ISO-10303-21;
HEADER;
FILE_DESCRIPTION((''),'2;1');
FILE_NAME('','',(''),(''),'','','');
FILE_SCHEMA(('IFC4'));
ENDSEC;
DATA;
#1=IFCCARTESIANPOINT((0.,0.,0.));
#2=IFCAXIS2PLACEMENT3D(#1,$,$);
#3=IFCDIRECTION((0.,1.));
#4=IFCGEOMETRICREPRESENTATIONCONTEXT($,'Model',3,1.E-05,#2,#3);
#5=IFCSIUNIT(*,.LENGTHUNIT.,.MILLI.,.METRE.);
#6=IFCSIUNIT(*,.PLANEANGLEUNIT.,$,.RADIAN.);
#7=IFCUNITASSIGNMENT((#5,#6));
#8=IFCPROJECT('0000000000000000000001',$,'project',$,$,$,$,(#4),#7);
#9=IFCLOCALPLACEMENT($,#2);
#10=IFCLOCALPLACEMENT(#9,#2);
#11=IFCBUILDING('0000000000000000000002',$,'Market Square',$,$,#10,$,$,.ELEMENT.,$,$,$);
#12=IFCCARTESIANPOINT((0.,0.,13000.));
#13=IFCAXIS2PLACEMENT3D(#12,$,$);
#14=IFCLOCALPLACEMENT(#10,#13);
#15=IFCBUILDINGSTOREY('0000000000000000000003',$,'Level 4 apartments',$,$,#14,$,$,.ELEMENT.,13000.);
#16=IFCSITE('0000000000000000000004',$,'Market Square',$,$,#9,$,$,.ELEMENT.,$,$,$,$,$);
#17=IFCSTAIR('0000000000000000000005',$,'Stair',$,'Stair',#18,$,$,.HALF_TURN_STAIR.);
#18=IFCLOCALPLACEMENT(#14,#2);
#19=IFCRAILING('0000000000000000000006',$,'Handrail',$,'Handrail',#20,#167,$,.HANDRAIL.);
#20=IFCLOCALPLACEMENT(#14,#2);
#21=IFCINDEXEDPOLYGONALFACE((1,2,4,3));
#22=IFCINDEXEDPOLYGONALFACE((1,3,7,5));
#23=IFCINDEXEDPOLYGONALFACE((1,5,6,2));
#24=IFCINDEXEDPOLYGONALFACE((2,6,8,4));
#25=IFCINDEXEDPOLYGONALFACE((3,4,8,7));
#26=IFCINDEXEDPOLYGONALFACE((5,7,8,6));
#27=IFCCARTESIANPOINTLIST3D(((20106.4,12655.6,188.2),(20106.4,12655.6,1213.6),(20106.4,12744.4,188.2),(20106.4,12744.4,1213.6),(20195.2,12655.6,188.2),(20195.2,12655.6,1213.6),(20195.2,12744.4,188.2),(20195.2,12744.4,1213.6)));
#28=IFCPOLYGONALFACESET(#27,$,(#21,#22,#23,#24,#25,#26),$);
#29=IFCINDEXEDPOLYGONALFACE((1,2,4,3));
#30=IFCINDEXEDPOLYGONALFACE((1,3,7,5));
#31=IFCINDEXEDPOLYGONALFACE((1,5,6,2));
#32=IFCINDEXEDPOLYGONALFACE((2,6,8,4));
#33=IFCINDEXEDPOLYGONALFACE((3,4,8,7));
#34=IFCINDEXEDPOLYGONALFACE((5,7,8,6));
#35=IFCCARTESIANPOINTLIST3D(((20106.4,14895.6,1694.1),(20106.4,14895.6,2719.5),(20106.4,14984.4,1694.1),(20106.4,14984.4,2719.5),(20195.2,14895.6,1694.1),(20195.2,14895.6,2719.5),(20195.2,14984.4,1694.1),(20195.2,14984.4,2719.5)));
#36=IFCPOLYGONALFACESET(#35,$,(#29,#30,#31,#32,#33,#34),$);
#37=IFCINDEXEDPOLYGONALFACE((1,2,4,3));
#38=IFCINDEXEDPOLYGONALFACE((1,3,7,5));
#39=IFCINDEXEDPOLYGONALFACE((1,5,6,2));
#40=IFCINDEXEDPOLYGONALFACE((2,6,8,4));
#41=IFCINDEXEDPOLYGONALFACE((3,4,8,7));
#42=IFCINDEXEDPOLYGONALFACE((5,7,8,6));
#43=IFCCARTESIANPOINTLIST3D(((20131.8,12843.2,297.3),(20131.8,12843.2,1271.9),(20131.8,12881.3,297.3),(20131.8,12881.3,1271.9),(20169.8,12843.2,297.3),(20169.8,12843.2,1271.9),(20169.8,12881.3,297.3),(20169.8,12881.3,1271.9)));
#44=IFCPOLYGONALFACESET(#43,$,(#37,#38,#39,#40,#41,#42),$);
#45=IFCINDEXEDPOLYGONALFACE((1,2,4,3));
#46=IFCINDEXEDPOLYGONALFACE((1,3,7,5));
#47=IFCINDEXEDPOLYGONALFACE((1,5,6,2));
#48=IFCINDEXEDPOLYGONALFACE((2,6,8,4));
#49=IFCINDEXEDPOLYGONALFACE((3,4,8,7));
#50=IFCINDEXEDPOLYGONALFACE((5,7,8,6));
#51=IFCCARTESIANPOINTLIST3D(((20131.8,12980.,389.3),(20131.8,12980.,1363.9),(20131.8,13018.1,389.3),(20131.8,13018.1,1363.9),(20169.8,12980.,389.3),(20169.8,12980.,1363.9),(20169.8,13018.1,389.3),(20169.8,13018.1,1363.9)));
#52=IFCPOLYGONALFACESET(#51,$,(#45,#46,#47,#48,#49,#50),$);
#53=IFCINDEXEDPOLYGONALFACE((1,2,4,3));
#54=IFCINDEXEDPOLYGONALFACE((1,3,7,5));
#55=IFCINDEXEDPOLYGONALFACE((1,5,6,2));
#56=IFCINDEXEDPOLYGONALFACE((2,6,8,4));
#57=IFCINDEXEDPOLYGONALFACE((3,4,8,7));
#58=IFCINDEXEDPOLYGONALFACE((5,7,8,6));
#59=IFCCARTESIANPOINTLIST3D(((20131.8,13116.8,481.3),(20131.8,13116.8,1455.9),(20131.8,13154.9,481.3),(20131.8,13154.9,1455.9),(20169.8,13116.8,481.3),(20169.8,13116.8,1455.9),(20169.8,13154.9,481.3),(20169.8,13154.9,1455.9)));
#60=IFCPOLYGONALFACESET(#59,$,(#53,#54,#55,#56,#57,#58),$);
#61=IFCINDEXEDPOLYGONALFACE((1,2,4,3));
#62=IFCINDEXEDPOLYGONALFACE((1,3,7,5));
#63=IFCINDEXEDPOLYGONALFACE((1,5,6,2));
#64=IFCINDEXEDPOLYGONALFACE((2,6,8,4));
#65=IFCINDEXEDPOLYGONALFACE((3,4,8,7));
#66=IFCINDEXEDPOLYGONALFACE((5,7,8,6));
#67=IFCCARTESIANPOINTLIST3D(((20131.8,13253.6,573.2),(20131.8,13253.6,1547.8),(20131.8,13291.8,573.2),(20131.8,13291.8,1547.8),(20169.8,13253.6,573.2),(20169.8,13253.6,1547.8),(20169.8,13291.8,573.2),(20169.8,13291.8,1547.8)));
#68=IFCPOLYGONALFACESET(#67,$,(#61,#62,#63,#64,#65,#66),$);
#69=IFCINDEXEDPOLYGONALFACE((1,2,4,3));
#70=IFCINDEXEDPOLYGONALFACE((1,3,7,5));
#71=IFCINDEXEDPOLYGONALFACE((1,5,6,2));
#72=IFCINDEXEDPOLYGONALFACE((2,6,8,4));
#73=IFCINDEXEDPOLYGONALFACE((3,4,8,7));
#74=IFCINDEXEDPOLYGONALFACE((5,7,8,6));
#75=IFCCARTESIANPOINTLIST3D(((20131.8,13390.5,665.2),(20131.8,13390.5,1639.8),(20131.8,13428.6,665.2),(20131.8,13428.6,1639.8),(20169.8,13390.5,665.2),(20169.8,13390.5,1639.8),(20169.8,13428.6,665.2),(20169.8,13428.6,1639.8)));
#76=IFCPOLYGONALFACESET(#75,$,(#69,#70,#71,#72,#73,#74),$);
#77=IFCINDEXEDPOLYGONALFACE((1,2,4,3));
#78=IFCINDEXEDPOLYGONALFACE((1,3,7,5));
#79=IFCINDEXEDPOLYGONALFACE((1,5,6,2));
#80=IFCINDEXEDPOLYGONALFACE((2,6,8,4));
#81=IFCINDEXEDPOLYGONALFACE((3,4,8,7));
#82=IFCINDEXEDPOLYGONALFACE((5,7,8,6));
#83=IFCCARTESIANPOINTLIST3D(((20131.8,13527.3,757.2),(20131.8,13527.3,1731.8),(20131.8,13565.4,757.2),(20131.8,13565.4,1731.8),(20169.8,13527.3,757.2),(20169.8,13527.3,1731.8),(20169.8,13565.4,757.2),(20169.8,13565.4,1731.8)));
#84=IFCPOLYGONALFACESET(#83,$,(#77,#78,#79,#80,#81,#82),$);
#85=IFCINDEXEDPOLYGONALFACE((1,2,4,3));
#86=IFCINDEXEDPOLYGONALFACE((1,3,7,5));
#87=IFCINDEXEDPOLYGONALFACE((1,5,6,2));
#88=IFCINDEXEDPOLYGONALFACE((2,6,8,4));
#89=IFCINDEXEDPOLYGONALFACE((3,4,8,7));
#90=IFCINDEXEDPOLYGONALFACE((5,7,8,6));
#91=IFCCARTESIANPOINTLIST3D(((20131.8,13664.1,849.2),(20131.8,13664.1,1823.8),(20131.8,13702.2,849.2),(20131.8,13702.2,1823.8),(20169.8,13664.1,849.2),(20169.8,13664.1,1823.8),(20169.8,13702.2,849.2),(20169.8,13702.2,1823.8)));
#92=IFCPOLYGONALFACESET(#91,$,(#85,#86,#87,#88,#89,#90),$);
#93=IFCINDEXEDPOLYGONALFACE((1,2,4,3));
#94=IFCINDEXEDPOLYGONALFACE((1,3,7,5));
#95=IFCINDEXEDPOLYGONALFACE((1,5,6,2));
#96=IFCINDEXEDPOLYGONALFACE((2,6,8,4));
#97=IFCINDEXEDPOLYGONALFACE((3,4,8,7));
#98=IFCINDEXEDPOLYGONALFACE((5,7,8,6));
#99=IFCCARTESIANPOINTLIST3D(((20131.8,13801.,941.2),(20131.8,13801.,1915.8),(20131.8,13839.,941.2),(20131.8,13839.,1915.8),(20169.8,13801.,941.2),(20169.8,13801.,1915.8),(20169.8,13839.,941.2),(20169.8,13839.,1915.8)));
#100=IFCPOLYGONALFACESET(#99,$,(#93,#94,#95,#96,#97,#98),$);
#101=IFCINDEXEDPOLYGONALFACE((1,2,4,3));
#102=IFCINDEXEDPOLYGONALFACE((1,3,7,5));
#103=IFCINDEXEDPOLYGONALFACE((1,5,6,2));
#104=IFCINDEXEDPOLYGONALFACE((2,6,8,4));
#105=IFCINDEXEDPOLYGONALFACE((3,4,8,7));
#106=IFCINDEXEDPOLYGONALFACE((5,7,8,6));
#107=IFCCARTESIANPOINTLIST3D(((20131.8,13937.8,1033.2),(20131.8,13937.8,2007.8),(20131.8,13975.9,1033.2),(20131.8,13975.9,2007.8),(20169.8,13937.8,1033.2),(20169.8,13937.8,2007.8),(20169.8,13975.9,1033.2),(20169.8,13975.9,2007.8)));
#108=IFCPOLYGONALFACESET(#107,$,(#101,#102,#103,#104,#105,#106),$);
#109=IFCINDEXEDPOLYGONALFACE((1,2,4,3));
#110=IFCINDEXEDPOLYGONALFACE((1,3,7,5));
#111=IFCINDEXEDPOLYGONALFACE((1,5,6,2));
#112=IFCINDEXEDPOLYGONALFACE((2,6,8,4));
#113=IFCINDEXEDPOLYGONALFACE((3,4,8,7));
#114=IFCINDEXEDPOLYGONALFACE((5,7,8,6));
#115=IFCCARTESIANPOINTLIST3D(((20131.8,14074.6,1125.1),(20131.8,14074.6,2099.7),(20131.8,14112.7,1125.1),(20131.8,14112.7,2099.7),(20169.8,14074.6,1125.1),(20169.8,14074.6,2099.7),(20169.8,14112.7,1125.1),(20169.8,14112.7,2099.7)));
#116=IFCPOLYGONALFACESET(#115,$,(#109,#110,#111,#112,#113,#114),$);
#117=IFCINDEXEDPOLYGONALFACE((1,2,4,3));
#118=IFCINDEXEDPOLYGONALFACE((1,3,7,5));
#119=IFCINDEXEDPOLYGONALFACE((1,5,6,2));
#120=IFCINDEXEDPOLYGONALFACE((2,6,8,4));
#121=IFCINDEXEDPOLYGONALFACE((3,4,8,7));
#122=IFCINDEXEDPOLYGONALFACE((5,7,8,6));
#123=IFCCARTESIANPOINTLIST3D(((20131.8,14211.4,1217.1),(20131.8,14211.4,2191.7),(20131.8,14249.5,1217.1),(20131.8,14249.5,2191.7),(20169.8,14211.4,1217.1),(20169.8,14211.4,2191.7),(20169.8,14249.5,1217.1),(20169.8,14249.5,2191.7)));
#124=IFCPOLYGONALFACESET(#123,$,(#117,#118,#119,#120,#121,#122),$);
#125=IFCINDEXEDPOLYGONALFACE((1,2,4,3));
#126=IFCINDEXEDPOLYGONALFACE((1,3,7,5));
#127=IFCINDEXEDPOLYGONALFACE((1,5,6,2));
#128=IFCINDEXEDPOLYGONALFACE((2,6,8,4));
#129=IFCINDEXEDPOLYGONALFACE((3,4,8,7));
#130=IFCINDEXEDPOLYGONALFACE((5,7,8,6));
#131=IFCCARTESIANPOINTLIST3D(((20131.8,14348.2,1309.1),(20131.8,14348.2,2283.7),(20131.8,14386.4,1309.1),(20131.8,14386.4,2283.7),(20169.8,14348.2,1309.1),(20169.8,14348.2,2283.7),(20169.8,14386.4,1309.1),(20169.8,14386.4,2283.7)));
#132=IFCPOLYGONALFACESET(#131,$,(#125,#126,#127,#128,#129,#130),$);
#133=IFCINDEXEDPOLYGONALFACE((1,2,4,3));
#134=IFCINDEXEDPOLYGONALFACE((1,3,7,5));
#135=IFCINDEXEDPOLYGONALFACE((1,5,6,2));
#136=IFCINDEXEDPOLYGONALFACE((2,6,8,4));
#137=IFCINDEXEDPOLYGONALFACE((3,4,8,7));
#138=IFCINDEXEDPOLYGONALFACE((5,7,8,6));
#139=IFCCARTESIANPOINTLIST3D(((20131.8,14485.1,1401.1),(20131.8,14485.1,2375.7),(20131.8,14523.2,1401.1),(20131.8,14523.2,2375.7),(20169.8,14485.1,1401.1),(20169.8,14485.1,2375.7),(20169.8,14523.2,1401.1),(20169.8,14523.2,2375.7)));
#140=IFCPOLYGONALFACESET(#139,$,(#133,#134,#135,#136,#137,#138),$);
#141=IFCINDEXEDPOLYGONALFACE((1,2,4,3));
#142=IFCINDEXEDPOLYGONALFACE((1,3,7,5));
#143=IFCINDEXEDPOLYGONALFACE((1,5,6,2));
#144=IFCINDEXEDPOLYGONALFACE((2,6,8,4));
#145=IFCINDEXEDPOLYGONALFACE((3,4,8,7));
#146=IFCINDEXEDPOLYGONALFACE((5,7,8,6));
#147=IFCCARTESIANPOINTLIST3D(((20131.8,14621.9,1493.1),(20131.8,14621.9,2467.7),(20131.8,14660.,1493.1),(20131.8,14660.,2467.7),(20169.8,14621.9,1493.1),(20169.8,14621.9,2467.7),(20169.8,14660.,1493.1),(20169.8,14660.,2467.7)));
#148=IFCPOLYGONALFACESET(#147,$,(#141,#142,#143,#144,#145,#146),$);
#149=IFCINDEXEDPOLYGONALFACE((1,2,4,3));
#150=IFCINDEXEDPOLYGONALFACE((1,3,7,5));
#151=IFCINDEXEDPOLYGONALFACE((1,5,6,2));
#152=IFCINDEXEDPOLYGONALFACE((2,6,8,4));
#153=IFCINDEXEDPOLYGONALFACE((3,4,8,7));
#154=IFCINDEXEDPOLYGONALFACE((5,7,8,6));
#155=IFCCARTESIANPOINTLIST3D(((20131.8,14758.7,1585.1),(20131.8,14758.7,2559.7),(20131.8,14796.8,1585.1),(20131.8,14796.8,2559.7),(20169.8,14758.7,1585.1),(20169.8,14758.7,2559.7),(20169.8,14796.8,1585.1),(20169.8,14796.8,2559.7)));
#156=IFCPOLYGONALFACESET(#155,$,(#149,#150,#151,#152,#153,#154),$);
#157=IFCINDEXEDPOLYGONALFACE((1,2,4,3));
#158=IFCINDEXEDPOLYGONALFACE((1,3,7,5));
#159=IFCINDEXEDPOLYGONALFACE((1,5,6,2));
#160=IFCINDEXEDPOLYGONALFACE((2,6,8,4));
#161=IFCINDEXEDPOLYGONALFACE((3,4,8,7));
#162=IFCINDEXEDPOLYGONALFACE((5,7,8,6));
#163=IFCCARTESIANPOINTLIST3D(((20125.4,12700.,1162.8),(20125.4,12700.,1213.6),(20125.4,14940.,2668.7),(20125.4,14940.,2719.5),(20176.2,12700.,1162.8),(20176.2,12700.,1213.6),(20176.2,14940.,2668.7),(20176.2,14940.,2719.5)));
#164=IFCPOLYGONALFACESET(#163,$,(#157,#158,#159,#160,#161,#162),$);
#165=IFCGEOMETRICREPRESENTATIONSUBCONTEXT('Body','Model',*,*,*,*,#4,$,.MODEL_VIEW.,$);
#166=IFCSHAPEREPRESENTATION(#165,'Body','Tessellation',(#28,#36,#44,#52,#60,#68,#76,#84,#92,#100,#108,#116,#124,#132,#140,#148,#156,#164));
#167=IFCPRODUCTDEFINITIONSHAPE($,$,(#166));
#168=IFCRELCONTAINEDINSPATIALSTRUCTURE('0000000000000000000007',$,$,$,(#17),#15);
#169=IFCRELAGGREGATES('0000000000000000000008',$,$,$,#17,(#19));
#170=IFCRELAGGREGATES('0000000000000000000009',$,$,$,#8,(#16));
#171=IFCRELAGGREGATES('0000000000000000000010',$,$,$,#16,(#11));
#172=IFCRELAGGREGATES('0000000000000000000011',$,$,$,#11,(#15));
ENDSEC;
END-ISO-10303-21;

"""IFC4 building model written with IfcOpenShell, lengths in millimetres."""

from ifc_helpers import new_model, si_unit, direction, frame, origin, origin_with_axes, place, context, subcontext, project, spatial, polyline, outline, extrude, element, aggregate, save


model = new_model("IFC4")

# Units and contexts
model_context = context("Model", 3, precision=1e-05, world=origin(), true_north=direction((0.0, 1.0)))
body_context = subcontext(model_context, "Body", "Model", "MODEL_VIEW")
ifc_project = project(units=[si_unit("LENGTHUNIT", "METRE", prefix="MILLI"), si_unit("PLANEANGLEUNIT", "RADIAN")], contexts=[model_context])

# Site, building, storey
site_placement = place(None, origin())
site = spatial("IfcSite", under=ifc_project, at=site_placement, Name="Market Square", CompositionType="ELEMENT")
building_placement = place(site_placement, origin())
building = spatial("IfcBuilding", under=site, at=building_placement, Name="Market Square", CompositionType="ELEMENT")
storey_placement = place(building_placement, frame((0.0, 0.0, 13000.0)))
storey = spatial("IfcBuildingStorey", under=building, at=storey_placement, Name="Level 4 apartments", CompositionType="ELEMENT", Elevation=13000.0)

# Stair
stair_placement = place(storey_placement, origin_with_axes())
stair = element("IfcStair", 1, at=stair_placement, inside=storey, Name="Stair", ObjectType="Stair", PredefinedType="HALF_TURN_STAIR")

# Railing
railing_1_placement = place(storey_placement, origin_with_axes())
railing_1 = element("IfcRailing", 2, at=railing_1_placement, Name="Handrail", ObjectType="Handrail", PredefinedType="HANDRAIL", context=body_context, shape_type="SweptSolid", body=[
    extrude(outline(polyline([(-44.5, -44.5), (44.5, -44.5), (44.5, 44.5), (-44.5, 44.5), (-44.5, -44.5)])), frame((20150.8, 12700.0, 188.2), z_axis=(0.0, 0.0, 1.0), x_axis=(1.0, 0.0, 0.0)), (0.0, 0.0, 1.0), 1025.4),
    extrude(outline(polyline([(-44.5, -44.5), (44.5, -44.5), (44.5, 44.5), (-44.5, 44.5), (-44.5, -44.5)])), frame((20150.8, 14940.0, 1694.1), z_axis=(0.0, 0.0, 1.0), x_axis=(1.0, 0.0, 0.0)), (0.0, 0.0, 1.0), 1025.4),
    extrude(outline(polyline([(-19.1, -19.1), (19.1, -19.1), (19.1, 19.1), (-19.1, 19.1), (-19.1, -19.1)])), frame((20150.8, 12862.2, 297.3), z_axis=(0.0, 0.0, 1.0), x_axis=(1.0, 0.0, 0.0)), (0.0, 0.0, 1.0), 974.6),
    extrude(outline(polyline([(-19.1, -19.1), (19.1, -19.1), (19.1, 19.1), (-19.1, 19.1), (-19.1, -19.1)])), frame((20150.8, 12999.0, 389.3), z_axis=(0.0, 0.0, 1.0), x_axis=(1.0, 0.0, 0.0)), (0.0, 0.0, 1.0), 974.6),
    extrude(outline(polyline([(-19.1, -19.1), (19.1, -19.1), (19.1, 19.1), (-19.1, 19.1), (-19.1, -19.1)])), frame((20150.8, 13135.9, 481.3), z_axis=(0.0, 0.0, 1.0), x_axis=(1.0, 0.0, 0.0)), (0.0, 0.0, 1.0), 974.6),
    extrude(outline(polyline([(-19.1, -19.1), (19.1, -19.1), (19.1, 19.1), (-19.1, 19.1), (-19.1, -19.1)])), frame((20150.8, 13272.7, 573.2), z_axis=(0.0, 0.0, 1.0), x_axis=(1.0, 0.0, 0.0)), (0.0, 0.0, 1.0), 974.6),
    extrude(outline(polyline([(-19.1, -19.1), (19.1, -19.1), (19.1, 19.1), (-19.1, 19.1), (-19.1, -19.1)])), frame((20150.8, 13409.5, 665.2), z_axis=(0.0, 0.0, 1.0), x_axis=(1.0, 0.0, 0.0)), (0.0, 0.0, 1.0), 974.6),
    extrude(outline(polyline([(-19.1, -19.1), (19.1, -19.1), (19.1, 19.1), (-19.1, 19.1), (-19.1, -19.1)])), frame((20150.8, 13546.4, 757.2), z_axis=(0.0, 0.0, 1.0), x_axis=(1.0, 0.0, 0.0)), (0.0, 0.0, 1.0), 974.6),
    extrude(outline(polyline([(-19.1, -19.1), (19.1, -19.1), (19.1, 19.1), (-19.1, 19.1), (-19.1, -19.1)])), frame((20150.8, 13683.2, 849.2), z_axis=(0.0, 0.0, 1.0), x_axis=(1.0, 0.0, 0.0)), (0.0, 0.0, 1.0), 974.6),
    extrude(outline(polyline([(-19.1, -19.1), (19.1, -19.1), (19.1, 19.1), (-19.1, 19.1), (-19.1, -19.1)])), frame((20150.8, 13820.0, 941.2), z_axis=(0.0, 0.0, 1.0), x_axis=(1.0, 0.0, 0.0)), (0.0, 0.0, 1.0), 974.6),
    extrude(outline(polyline([(-19.1, -19.1), (19.1, -19.1), (19.1, 19.1), (-19.1, 19.1), (-19.1, -19.1)])), frame((20150.8, 13956.8, 1033.2), z_axis=(0.0, 0.0, 1.0), x_axis=(1.0, 0.0, 0.0)), (0.0, 0.0, 1.0), 974.6),
    extrude(outline(polyline([(-19.1, -19.1), (19.1, -19.1), (19.1, 19.1), (-19.1, 19.1), (-19.1, -19.1)])), frame((20150.8, 14093.6, 1125.1), z_axis=(0.0, 0.0, 1.0), x_axis=(1.0, 0.0, 0.0)), (0.0, 0.0, 1.0), 974.6),
    extrude(outline(polyline([(-19.1, -19.1), (19.1, -19.1), (19.1, 19.1), (-19.1, 19.1), (-19.1, -19.1)])), frame((20150.8, 14230.5, 1217.1), z_axis=(0.0, 0.0, 1.0), x_axis=(1.0, 0.0, 0.0)), (0.0, 0.0, 1.0), 974.6),
    extrude(outline(polyline([(-19.1, -19.1), (19.1, -19.1), (19.1, 19.1), (-19.1, 19.1), (-19.1, -19.1)])), frame((20150.8, 14367.3, 1309.1), z_axis=(0.0, 0.0, 1.0), x_axis=(1.0, 0.0, 0.0)), (0.0, 0.0, 1.0), 974.6),
    extrude(outline(polyline([(-19.1, -19.1), (19.1, -19.1), (19.1, 19.1), (-19.1, 19.1), (-19.1, -19.1)])), frame((20150.8, 14504.1, 1401.1), z_axis=(0.0, 0.0, 1.0), x_axis=(1.0, 0.0, 0.0)), (0.0, 0.0, 1.0), 974.6),
    extrude(outline(polyline([(-19.1, -19.1), (19.1, -19.1), (19.1, 19.1), (-19.1, 19.1), (-19.1, -19.1)])), frame((20150.8, 14641.0, 1493.1), z_axis=(0.0, 0.0, 1.0), x_axis=(1.0, 0.0, 0.0)), (0.0, 0.0, 1.0), 974.6),
    extrude(outline(polyline([(-19.1, -19.1), (19.1, -19.1), (19.1, 19.1), (-19.1, 19.1), (-19.1, -19.1)])), frame((20150.8, 14777.8, 1585.1), z_axis=(0.0, 0.0, 1.0), x_axis=(1.0, 0.0, 0.0)), (0.0, 0.0, 1.0), 974.6),
    extrude(outline(polyline([(0.0, 0.0), (50.8, 0.0), (50.8, 50.8), (0.0, 50.8), (0.0, 0.0)])), frame((20176.2, 12700.0, 1162.8), z_axis=(0.0, 1.0, 0.0), x_axis=(-1.0, 0.0, 0.0)), (0.0, 0.557915, 0.829898), 2699.1),
])
aggregate(stair, [railing_1])

save(model, "model.ifc")
